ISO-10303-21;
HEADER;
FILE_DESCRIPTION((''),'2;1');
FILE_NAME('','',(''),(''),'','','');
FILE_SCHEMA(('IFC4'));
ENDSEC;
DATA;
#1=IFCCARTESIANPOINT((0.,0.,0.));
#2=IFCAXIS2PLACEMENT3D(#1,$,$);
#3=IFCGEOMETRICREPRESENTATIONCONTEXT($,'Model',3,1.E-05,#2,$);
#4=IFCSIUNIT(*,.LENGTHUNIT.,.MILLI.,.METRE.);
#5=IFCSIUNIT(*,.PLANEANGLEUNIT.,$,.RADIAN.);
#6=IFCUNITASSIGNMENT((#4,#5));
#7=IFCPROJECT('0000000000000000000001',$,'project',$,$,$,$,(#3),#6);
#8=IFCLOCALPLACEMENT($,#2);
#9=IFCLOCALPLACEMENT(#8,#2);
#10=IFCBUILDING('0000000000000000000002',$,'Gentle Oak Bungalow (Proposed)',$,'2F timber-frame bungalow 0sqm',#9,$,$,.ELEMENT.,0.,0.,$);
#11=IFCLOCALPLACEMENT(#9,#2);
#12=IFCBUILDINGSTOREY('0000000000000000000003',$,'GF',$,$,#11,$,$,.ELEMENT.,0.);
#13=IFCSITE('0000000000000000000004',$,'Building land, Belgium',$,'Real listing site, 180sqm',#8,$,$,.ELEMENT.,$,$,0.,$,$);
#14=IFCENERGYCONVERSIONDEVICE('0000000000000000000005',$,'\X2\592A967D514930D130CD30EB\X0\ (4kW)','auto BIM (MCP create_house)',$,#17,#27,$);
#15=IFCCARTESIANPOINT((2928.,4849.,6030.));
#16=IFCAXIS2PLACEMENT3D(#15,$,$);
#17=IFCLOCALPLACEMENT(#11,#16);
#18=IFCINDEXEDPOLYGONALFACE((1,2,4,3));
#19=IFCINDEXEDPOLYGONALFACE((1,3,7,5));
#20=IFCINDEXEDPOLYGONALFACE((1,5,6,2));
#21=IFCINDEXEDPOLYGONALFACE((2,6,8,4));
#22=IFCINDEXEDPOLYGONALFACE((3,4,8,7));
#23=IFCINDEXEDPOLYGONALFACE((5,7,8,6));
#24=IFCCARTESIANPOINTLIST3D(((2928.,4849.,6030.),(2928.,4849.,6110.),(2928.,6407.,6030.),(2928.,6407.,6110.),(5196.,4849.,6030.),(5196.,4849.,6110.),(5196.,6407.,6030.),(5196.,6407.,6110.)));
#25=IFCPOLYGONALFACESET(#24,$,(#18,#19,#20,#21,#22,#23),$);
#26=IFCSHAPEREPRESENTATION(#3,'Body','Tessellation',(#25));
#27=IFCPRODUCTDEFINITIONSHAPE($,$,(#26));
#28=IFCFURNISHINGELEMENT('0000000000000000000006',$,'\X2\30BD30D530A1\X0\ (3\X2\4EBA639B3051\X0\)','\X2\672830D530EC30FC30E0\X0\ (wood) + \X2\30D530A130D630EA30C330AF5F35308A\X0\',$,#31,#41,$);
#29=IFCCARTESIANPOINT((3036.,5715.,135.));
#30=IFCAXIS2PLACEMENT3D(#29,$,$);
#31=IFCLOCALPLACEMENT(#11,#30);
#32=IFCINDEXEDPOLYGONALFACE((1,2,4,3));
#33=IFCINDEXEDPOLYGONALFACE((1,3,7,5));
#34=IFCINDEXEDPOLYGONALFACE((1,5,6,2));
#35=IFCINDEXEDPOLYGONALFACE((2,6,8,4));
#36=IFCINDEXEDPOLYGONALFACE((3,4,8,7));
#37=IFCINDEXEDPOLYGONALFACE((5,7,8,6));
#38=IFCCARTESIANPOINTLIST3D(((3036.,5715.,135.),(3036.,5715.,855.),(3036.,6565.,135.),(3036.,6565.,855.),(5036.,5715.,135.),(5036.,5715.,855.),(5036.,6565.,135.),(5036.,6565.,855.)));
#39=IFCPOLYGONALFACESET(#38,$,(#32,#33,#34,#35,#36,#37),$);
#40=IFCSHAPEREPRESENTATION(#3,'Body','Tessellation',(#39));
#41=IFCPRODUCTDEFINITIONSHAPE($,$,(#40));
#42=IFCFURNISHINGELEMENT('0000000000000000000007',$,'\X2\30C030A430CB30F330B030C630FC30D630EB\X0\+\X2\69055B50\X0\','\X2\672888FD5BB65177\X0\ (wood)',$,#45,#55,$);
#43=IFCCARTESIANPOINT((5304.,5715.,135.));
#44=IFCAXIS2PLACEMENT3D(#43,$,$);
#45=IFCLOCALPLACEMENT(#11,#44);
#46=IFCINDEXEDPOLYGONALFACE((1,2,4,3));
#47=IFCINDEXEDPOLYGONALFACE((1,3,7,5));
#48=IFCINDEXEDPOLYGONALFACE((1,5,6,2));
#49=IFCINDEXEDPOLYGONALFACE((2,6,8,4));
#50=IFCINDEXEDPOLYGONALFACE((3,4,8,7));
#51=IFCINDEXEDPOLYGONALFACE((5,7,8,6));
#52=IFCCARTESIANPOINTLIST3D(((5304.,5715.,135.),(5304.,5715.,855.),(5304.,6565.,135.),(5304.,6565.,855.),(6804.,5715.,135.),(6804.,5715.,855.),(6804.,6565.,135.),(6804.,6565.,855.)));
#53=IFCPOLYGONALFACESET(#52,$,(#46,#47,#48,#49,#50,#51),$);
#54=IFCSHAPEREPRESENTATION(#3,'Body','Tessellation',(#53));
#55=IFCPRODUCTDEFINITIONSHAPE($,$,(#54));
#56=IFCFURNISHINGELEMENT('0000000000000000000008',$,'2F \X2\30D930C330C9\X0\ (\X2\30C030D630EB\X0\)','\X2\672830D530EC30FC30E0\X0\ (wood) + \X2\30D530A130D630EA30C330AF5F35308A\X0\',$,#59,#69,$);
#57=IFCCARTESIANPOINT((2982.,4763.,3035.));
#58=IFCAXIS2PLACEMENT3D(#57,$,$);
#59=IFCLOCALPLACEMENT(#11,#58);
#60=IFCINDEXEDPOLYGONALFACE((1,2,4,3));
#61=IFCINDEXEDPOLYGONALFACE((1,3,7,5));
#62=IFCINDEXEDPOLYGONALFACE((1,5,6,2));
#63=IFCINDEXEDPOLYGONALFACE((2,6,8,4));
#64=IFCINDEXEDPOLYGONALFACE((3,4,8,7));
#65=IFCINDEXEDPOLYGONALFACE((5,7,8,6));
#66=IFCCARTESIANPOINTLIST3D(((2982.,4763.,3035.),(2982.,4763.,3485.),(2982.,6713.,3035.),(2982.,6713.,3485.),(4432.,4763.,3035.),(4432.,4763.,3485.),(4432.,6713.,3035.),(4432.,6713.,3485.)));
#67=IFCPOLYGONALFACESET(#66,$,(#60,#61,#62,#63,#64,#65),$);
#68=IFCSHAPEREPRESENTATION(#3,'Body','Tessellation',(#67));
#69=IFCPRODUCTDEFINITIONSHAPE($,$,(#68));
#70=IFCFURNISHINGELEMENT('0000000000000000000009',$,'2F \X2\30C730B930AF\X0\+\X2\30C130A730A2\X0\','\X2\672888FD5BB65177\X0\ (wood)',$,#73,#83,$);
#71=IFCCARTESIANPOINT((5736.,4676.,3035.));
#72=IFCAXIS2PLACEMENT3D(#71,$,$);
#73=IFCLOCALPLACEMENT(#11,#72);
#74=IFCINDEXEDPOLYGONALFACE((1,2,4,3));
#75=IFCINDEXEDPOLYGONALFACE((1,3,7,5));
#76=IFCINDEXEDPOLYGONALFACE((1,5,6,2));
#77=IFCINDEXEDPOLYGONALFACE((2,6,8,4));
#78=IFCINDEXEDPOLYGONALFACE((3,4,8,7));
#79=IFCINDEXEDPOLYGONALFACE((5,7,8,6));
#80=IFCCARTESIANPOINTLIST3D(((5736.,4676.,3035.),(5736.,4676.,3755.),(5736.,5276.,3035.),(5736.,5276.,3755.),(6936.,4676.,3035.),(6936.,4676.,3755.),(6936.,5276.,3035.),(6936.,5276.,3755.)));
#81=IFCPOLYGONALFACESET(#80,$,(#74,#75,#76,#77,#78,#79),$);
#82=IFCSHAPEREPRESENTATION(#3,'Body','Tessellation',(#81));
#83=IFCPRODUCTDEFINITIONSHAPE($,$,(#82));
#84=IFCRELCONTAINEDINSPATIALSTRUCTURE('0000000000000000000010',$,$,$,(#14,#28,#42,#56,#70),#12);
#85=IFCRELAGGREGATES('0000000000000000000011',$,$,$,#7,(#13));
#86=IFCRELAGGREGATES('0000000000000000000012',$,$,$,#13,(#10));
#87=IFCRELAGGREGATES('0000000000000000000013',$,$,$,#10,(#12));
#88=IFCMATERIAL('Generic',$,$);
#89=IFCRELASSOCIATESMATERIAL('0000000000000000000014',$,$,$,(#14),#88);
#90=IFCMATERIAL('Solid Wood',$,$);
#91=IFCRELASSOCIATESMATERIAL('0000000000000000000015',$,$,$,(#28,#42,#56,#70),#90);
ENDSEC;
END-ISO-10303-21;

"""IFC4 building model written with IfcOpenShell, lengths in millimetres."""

from ifc_helpers import new_model, si_unit, frame, frame_2d, origin, place, context, project, spatial, rectangle, extrude, material, element, save


model = new_model("IFC4")

# Units and contexts
model_context = context("Model", 3, precision=1e-05, world=origin())
ifc_project = project(units=[si_unit("LENGTHUNIT", "METRE", prefix="MILLI"), si_unit("PLANEANGLEUNIT", "RADIAN")], contexts=[model_context])

# Site, building, storey
site_placement = place(None, origin())
site = spatial("IfcSite", under=ifc_project, at=site_placement, Name="Building land, Belgium", ObjectType="Real listing site, 180sqm", CompositionType="ELEMENT", RefElevation=0.0)
building_placement = place(site_placement, origin())
building = spatial("IfcBuilding", under=site, at=building_placement, Name="Gentle Oak Bungalow (Proposed)", ObjectType="2F timber-frame bungalow 0sqm", CompositionType="ELEMENT", ElevationOfRefHeight=0.0, ElevationOfTerrain=0.0)
storey_placement = place(building_placement, origin())
storey = spatial("IfcBuildingStorey", under=building, at=storey_placement, Name="GF", CompositionType="ELEMENT", Elevation=0.0)

# Shared definitions
ifc_material_1 = material(Name="Solid Wood")

# Shared definitions
ifc_material_2 = material(Name="Generic")

# Energy conversion device
energy_conversion_device_placement = place(storey_placement, frame((2928.0, 4849.0, 6030.0)))
element("IfcEnergyConversionDevice", 1, at=energy_conversion_device_placement, inside=storey, material=ifc_material_2, Name="太陽光パネル (4kW)", Description="auto BIM (MCP create_house)", context=model_context, shape_type="SweptSolid", body=[
    extrude(rectangle(XDim=2268.0, YDim=1558.0, at=frame_2d((1134.0, 779.0))), frame((2928.0, 4849.0, 6030.0)), (0.0, 0.0, 1.0), 80.0),
])

# Furnishing elements
furnishing_1_placement = place(storey_placement, frame((3036.0, 5715.0, 135.0)))
element("IfcFurnishingElement", 2, at=furnishing_1_placement, inside=storey, material=ifc_material_1, Name="ソファ (3人掛け)", Description="木フレーム (wood) + ファブリック張り", context=model_context, shape_type="SweptSolid", body=[
    extrude(rectangle(XDim=2000.0, YDim=850.0, at=frame_2d((1000.0, 425.0))), frame((3036.0, 5715.0, 135.0)), (0.0, 0.0, 1.0), 720.0),
])
furnishing_2_placement = place(storey_placement, frame((5304.0, 5715.0, 135.0)))
element("IfcFurnishingElement", 3, at=furnishing_2_placement, inside=storey, material=ifc_material_1, Name="ダイニングテーブル+椅子", Description="木製家具 (wood)", context=model_context, shape_type="SweptSolid", body=[
    extrude(rectangle(XDim=1500.0, YDim=850.0, at=frame_2d((750.0, 425.0))), frame((5304.0, 5715.0, 135.0)), (0.0, 0.0, 1.0), 720.0),
])
furnishing_3_placement = place(storey_placement, frame((2982.0, 4763.0, 3035.0)))
element("IfcFurnishingElement", 4, at=furnishing_3_placement, inside=storey, material=ifc_material_1, Name="2F ベッド (ダブル)", Description="木フレーム (wood) + ファブリック張り", context=model_context, shape_type="SweptSolid", body=[
    extrude(rectangle(XDim=1450.0, YDim=1950.0, at=frame_2d((725.0, 975.0))), frame((2982.0, 4763.0, 3035.0)), (0.0, 0.0, 1.0), 450.0),
])
furnishing_4_placement = place(storey_placement, frame((5736.0, 4676.0, 3035.0)))
element("IfcFurnishingElement", 5, at=furnishing_4_placement, inside=storey, material=ifc_material_1, Name="2F デスク+チェア", Description="木製家具 (wood)", context=model_context, shape_type="SweptSolid", body=[
    extrude(rectangle(XDim=1200.0, YDim=600.0, at=frame_2d((600.0, 300.0))), frame((5736.0, 4676.0, 3035.0)), (0.0, 0.0, 1.0), 720.0),
])

save(model, "model.ifc")
